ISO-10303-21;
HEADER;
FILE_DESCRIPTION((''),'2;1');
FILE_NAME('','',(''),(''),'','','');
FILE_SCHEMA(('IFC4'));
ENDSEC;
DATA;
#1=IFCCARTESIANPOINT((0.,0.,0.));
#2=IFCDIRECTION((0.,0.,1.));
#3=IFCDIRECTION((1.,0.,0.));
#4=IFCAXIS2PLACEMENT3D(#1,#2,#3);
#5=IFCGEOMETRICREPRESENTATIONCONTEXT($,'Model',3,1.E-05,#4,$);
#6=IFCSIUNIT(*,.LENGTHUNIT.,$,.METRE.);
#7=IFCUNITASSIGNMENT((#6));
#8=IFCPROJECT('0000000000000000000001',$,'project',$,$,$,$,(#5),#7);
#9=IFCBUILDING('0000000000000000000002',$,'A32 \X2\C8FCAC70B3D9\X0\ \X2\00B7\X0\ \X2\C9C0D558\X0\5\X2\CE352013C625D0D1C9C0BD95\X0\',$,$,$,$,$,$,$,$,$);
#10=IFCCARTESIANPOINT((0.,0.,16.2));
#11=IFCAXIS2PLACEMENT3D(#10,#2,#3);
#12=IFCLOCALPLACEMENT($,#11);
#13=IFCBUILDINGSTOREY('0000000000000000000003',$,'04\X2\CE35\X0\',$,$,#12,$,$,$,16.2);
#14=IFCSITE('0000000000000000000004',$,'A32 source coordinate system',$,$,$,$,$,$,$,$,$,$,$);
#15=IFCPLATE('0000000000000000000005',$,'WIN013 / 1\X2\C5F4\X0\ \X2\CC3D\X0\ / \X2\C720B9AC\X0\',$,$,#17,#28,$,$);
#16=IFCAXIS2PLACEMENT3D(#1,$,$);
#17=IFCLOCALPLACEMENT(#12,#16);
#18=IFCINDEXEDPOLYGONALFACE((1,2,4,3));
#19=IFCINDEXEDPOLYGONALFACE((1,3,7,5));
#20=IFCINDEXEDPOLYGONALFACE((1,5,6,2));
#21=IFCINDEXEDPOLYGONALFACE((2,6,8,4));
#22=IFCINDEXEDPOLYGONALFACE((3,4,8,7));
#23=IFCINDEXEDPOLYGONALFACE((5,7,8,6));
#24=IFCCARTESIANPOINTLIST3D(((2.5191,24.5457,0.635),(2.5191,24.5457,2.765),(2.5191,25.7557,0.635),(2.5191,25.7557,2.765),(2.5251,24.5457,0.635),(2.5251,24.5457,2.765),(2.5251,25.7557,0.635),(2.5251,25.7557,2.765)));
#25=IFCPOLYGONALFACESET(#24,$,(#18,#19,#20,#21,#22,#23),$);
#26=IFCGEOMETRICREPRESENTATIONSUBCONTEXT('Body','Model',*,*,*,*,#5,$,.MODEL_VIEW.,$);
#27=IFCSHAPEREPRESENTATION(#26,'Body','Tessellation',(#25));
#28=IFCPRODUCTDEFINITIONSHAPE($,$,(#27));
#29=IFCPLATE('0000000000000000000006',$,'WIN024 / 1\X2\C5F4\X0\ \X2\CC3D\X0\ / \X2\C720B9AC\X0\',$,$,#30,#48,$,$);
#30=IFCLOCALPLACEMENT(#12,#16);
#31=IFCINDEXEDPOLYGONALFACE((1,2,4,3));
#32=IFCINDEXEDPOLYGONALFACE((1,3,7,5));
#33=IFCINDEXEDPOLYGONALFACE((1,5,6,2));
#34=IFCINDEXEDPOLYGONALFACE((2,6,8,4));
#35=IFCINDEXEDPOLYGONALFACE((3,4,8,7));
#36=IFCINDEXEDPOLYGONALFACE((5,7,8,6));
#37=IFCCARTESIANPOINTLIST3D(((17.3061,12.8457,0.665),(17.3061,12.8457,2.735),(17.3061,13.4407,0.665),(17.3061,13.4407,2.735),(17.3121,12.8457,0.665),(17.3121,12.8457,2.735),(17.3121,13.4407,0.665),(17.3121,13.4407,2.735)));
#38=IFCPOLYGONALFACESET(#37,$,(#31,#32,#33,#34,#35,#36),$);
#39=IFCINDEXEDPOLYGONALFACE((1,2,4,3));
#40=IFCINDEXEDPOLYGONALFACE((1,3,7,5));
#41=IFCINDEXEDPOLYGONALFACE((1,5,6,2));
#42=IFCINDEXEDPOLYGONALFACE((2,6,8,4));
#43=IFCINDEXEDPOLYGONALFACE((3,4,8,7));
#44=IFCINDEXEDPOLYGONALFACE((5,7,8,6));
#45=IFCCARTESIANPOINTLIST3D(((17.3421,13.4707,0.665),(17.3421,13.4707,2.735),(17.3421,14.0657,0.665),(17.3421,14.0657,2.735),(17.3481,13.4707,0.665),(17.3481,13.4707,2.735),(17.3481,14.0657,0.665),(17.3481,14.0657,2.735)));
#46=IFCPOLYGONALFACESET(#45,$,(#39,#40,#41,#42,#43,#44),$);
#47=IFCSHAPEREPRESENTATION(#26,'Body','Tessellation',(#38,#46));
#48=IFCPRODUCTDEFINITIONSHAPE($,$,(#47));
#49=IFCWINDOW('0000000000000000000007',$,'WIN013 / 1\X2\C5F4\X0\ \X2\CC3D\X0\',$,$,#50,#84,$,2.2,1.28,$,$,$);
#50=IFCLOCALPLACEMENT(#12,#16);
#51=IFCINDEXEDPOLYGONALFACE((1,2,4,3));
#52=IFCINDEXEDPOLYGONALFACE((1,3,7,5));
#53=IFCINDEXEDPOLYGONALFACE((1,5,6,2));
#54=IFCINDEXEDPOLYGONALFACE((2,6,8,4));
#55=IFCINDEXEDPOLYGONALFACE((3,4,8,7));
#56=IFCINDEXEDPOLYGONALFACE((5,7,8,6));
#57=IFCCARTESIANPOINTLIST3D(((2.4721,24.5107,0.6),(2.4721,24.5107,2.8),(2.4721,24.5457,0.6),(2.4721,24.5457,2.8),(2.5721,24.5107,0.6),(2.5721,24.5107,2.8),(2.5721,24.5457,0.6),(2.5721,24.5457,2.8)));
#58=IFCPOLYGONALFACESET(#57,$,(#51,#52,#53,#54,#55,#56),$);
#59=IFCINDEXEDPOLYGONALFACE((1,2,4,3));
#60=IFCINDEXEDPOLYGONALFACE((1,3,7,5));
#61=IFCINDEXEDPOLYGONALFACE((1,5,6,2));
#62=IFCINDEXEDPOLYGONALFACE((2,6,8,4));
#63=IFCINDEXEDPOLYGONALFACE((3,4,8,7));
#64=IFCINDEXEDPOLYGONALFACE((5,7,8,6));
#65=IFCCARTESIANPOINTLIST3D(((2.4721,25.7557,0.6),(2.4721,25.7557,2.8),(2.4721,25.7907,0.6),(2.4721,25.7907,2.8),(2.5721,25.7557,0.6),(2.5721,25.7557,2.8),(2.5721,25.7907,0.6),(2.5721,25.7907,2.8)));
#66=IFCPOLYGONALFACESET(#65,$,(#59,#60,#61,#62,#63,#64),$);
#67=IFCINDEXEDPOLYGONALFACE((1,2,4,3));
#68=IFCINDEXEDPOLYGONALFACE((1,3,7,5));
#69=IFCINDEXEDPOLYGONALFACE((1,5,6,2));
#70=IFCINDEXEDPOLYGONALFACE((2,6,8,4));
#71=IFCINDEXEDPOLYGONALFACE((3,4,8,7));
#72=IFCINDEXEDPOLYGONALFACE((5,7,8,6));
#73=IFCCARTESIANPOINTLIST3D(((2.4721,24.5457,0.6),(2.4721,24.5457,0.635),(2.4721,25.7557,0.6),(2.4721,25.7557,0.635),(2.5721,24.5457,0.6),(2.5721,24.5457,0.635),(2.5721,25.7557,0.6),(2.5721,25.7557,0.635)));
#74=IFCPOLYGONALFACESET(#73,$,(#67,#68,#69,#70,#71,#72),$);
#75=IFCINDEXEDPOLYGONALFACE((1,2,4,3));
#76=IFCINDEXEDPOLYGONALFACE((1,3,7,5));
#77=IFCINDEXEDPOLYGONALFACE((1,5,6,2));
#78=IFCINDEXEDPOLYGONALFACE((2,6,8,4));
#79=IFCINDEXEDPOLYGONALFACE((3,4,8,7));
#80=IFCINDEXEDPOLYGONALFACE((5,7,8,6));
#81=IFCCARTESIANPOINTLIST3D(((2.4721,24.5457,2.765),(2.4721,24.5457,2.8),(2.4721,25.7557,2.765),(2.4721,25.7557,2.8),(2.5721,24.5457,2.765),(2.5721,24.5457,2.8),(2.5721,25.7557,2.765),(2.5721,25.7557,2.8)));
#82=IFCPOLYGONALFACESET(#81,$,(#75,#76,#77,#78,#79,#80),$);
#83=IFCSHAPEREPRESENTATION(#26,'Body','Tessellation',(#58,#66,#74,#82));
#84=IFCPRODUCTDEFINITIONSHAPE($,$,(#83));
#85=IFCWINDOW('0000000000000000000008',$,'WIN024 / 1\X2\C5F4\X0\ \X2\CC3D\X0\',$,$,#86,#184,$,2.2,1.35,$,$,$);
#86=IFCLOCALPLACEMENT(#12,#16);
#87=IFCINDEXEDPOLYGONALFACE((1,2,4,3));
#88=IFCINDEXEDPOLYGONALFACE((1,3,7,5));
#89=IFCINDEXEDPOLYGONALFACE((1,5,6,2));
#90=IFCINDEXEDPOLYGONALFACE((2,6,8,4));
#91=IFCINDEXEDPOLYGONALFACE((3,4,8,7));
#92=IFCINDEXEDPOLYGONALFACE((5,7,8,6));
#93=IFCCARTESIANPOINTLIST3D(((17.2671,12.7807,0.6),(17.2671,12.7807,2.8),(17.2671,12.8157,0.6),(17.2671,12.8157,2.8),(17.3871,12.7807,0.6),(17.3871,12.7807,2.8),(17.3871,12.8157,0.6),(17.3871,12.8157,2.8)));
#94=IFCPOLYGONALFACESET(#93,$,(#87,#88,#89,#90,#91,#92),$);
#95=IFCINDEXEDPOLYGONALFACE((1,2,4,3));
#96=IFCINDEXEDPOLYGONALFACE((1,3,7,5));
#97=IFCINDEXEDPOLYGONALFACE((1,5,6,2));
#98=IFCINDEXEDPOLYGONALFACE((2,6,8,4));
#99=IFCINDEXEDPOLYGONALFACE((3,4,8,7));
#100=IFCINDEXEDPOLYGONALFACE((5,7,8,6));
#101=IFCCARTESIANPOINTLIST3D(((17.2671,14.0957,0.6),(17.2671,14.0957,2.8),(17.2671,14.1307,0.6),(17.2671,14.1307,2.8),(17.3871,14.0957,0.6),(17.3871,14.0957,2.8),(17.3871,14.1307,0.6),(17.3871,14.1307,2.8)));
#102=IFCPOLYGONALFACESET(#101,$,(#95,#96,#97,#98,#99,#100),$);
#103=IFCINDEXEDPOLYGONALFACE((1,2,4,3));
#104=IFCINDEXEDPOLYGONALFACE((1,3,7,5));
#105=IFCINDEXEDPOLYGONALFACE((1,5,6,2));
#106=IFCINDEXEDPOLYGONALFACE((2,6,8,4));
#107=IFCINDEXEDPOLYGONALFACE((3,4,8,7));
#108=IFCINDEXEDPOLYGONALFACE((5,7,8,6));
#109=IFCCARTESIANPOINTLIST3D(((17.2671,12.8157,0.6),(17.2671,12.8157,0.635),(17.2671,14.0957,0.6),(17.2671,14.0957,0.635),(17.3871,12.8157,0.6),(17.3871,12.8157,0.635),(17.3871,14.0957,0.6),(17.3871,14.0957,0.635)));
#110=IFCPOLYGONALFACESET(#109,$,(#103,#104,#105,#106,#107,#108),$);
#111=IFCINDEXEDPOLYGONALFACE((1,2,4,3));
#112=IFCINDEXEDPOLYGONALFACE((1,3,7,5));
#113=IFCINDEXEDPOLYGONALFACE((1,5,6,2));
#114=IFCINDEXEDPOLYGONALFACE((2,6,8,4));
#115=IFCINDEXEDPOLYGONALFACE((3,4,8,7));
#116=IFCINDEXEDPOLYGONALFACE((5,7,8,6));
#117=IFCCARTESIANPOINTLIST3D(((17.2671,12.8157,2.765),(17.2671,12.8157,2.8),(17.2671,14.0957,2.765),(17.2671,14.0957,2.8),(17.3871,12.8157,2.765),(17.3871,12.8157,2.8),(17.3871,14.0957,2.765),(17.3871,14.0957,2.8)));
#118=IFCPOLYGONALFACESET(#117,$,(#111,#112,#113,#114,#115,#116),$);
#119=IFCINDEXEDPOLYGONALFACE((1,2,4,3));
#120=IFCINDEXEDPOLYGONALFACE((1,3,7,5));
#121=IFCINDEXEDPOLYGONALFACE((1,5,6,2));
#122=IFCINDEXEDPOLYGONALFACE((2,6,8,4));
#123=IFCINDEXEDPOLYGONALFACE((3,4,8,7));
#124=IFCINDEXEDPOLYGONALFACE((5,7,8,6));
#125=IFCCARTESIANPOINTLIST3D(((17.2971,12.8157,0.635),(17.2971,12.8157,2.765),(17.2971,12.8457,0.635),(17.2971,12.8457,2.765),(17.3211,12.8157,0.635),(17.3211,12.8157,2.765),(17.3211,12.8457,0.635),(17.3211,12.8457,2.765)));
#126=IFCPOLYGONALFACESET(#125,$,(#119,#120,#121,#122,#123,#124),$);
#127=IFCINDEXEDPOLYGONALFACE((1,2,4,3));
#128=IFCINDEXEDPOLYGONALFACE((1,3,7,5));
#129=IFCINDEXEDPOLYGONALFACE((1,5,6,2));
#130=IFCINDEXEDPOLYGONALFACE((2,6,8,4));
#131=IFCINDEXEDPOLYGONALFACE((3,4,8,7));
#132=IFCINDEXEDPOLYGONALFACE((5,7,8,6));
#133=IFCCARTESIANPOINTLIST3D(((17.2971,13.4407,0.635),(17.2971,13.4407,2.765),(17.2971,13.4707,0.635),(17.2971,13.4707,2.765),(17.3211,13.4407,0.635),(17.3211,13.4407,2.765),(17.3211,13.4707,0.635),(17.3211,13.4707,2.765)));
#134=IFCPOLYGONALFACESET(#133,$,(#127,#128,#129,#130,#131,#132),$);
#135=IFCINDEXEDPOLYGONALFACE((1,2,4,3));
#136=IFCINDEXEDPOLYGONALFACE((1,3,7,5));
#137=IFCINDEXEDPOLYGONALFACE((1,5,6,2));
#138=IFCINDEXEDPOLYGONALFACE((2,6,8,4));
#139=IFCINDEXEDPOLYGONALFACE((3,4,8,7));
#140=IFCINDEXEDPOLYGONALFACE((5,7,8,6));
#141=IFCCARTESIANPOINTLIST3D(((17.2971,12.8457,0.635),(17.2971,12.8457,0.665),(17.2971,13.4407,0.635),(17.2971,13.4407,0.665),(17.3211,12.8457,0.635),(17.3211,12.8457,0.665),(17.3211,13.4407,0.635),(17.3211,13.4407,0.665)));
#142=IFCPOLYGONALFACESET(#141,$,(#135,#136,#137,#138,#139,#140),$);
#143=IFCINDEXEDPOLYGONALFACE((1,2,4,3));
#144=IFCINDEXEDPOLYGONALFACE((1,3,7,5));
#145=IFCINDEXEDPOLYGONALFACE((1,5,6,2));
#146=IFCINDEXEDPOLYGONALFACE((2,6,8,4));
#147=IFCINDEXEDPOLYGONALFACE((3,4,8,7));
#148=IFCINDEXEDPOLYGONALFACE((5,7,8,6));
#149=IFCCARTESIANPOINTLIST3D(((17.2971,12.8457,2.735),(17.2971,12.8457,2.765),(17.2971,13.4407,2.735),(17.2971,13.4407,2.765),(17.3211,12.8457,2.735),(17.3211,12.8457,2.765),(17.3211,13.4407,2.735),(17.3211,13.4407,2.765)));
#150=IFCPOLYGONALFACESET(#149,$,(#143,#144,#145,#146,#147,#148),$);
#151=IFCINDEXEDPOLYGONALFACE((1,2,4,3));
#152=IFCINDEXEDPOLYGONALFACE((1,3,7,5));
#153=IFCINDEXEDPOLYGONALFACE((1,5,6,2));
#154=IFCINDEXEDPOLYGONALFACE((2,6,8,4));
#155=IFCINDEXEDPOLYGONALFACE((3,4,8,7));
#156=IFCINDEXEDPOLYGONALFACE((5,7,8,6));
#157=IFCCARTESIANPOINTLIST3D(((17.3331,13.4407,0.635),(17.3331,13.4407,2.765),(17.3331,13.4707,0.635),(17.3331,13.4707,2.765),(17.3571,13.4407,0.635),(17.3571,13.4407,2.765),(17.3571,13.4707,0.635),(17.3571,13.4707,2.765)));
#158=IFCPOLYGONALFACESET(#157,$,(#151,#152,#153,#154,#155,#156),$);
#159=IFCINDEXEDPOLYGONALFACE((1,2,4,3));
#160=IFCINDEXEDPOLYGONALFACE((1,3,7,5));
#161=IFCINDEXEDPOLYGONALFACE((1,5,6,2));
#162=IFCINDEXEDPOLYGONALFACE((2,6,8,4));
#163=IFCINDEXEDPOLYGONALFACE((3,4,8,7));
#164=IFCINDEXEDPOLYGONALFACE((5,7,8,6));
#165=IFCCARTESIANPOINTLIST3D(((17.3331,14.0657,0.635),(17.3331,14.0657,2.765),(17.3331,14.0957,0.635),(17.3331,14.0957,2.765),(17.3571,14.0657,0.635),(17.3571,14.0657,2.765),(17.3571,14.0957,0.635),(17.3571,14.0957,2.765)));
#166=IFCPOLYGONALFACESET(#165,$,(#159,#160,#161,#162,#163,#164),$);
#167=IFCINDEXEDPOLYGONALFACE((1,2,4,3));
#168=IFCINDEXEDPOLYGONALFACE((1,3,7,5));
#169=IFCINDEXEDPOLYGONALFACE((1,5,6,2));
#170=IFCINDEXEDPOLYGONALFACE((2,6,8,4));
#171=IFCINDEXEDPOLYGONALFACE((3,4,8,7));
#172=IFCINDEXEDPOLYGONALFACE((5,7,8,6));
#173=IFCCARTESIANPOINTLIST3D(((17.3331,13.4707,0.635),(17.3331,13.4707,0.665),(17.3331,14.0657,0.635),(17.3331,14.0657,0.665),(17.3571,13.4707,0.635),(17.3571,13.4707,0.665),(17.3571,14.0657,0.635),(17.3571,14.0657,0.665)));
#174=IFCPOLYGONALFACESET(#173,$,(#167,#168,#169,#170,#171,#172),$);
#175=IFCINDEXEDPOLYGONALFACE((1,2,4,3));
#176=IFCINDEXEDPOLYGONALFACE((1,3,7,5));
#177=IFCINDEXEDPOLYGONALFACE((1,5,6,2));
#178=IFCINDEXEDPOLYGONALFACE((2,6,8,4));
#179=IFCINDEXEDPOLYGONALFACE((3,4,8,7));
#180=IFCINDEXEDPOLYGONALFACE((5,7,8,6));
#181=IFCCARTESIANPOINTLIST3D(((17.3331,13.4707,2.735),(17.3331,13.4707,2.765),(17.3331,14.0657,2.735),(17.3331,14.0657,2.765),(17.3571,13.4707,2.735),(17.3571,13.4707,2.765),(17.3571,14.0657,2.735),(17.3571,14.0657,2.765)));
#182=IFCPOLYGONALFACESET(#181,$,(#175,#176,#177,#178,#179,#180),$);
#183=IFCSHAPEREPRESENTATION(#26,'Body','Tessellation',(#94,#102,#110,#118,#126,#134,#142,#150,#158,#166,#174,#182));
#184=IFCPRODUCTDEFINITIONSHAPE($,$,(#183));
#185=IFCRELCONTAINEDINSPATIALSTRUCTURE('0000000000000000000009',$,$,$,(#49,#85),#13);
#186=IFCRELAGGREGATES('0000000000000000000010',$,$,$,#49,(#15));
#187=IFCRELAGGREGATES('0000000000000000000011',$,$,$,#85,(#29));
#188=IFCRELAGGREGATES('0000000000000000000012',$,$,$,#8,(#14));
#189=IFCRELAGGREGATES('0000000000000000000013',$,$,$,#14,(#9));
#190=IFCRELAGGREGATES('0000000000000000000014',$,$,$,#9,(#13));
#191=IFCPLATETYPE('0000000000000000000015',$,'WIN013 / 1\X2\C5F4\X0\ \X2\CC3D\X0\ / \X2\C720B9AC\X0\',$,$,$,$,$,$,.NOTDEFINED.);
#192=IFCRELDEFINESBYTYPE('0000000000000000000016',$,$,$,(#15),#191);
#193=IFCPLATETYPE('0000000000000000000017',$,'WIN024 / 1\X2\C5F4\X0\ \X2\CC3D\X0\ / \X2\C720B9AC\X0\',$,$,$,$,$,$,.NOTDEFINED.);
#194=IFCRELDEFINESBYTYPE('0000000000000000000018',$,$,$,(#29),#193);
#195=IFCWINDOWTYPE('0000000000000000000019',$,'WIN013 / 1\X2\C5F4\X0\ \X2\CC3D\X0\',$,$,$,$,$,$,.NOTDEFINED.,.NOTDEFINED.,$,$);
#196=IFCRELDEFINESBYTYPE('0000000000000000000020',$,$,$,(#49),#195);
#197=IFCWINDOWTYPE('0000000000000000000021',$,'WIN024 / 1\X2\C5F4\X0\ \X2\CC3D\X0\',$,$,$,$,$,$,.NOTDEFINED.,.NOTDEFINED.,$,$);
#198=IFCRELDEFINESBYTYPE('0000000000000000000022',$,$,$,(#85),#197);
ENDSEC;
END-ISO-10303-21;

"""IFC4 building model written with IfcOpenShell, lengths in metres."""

from ifc_helpers import new_model, si_unit, frame, origin, origin_with_axes, place, context, subcontext, project, spatial, polyline, outline, extrude, source, transform, mapped, type_object, type_shapes, element, aggregate, save


model = new_model("IFC4")

# Units and contexts
model_context = context("Model", 3, precision=1e-05, world=origin_with_axes())
body_context = subcontext(model_context, "Body", "Model", "MODEL_VIEW")
ifc_project = project(units=[si_unit("LENGTHUNIT", "METRE")], contexts=[model_context])

# Plates
plate_type_1 = type_object("IfcPlateType", Name="WIN013 / 1열 창 / 유리", PredefinedType="NOTDEFINED")
shared_shape_1 = source(origin(), body_context, "Body", "SweptSolid", [
    extrude(outline(polyline([(2.5191, 24.5457), (2.5191, 25.7557), (2.5251, 25.7557), (2.5251, 24.5457), (2.5191, 24.5457)])), frame((0.0, 0.0, 0.635)), (0.0, 0.0, 1.0), 2.13),
])
type_shapes(plate_type_1, [shared_shape_1])
storey_placement = place(None, frame((0.0, 0.0, 16.2), z_axis=(0.0, 0.0, 1.0), x_axis=(1.0, 0.0, 0.0)))
window_1_placement = place(storey_placement, origin_with_axes())
plate_1_placement = place(window_1_placement, origin_with_axes())
plate_1 = element("IfcPlate", 1, at=plate_1_placement, type_object=plate_type_1, Name="WIN013 / 1열 창 / 유리", context=body_context, shape_type="MappedRepresentation", body=[
    mapped(shared_shape_1, transform((0.0, 0.0, 0.0), scale=1.0)),
])
plate_type_2 = type_object("IfcPlateType", Name="WIN024 / 1열 창 / 유리", PredefinedType="NOTDEFINED")
shared_shape_2 = source(origin(), body_context, "Body", "SweptSolid", [
    extrude(outline(polyline([(17.3061, 12.8457), (17.3061, 13.4407), (17.3121, 13.4407), (17.3121, 12.8457), (17.3061, 12.8457)])), frame((0.0, 0.0, 0.665)), (0.0, 0.0, 1.0), 2.07),
    extrude(outline(polyline([(17.3421, 13.4707), (17.3421, 14.0657), (17.3481, 14.0657), (17.3481, 13.4707), (17.3421, 13.4707)])), frame((0.0, 0.0, 0.665)), (0.0, 0.0, 1.0), 2.07),
])
type_shapes(plate_type_2, [shared_shape_2])
window_2_placement = place(storey_placement, origin_with_axes())
plate_2_placement = place(window_2_placement, origin_with_axes())
plate_2 = element("IfcPlate", 2, at=plate_2_placement, type_object=plate_type_2, Name="WIN024 / 1열 창 / 유리", context=body_context, shape_type="MappedRepresentation", body=[
    mapped(shared_shape_2, transform((0.0, 0.0, 0.0), scale=1.0)),
])

# Site, building, storey
site = spatial("IfcSite", under=ifc_project, Name="A32 source coordinate system")
building = spatial("IfcBuilding", under=site, Name="A32 주거동 · 지하5층–옥탑지붕")
storey = spatial("IfcBuildingStorey", under=building, at=storey_placement, Name="04층", Elevation=16.2)

# Windows
window_type_1 = type_object("IfcWindowType", Name="WIN013 / 1열 창", PartitioningType="NOTDEFINED", PredefinedType="NOTDEFINED")
shared_shape_3 = source(origin(), body_context, "Body", "SweptSolid", [
    extrude(outline(polyline([(2.4721, 24.5107), (2.4721, 24.5457), (2.5721, 24.5457), (2.5721, 24.5107), (2.4721, 24.5107)])), frame((0.0, 0.0, 0.6)), (0.0, 0.0, 1.0), 2.2),
    extrude(outline(polyline([(2.4721, 25.7557), (2.4721, 25.7907), (2.5721, 25.7907), (2.5721, 25.7557), (2.4721, 25.7557)])), frame((0.0, 0.0, 0.6)), (0.0, 0.0, 1.0), 2.2),
    extrude(outline(polyline([(2.4721, 24.5457), (2.4721, 25.7557), (2.5721, 25.7557), (2.5721, 24.5457), (2.4721, 24.5457)])), frame((0.0, 0.0, 0.6)), (0.0, 0.0, 1.0), 0.035),
    extrude(outline(polyline([(2.4721, 24.5457), (2.4721, 25.7557), (2.5721, 25.7557), (2.5721, 24.5457), (2.4721, 24.5457)])), frame((0.0, 0.0, 2.765)), (0.0, 0.0, 1.0), 0.035),
])
type_shapes(window_type_1, [shared_shape_3])
window_1 = element("IfcWindow", 3, at=window_1_placement, inside=storey, type_object=window_type_1, Name="WIN013 / 1열 창", OverallHeight=2.2, OverallWidth=1.28, context=body_context, shape_type="MappedRepresentation", body=[
    mapped(shared_shape_3, transform((0.0, 0.0, 0.0), scale=1.0)),
])
aggregate(window_1, [plate_1])
window_type_2 = type_object("IfcWindowType", Name="WIN024 / 1열 창", PartitioningType="NOTDEFINED", PredefinedType="NOTDEFINED")
shared_shape_4 = source(origin(), body_context, "Body", "SweptSolid", [
    extrude(outline(polyline([(17.2671, 12.7807), (17.2671, 12.8157), (17.3871, 12.8157), (17.3871, 12.7807), (17.2671, 12.7807)])), frame((0.0, 0.0, 0.6)), (0.0, 0.0, 1.0), 2.2),
    extrude(outline(polyline([(17.2671, 14.0957), (17.2671, 14.1307), (17.3871, 14.1307), (17.3871, 14.0957), (17.2671, 14.0957)])), frame((0.0, 0.0, 0.6)), (0.0, 0.0, 1.0), 2.2),
    extrude(outline(polyline([(17.2671, 12.8157), (17.2671, 14.0957), (17.3871, 14.0957), (17.3871, 12.8157), (17.2671, 12.8157)])), frame((0.0, 0.0, 0.6)), (0.0, 0.0, 1.0), 0.035),
    extrude(outline(polyline([(17.2671, 12.8157), (17.2671, 14.0957), (17.3871, 14.0957), (17.3871, 12.8157), (17.2671, 12.8157)])), frame((0.0, 0.0, 2.765)), (0.0, 0.0, 1.0), 0.035),
    extrude(outline(polyline([(17.2971, 12.8157), (17.2971, 12.8457), (17.3211, 12.8457), (17.3211, 12.8157), (17.2971, 12.8157)])), frame((0.0, 0.0, 0.635)), (0.0, 0.0, 1.0), 2.13),
    extrude(outline(polyline([(17.2971, 13.4407), (17.2971, 13.4707), (17.3211, 13.4707), (17.3211, 13.4407), (17.2971, 13.4407)])), frame((0.0, 0.0, 0.635)), (0.0, 0.0, 1.0), 2.13),
    extrude(outline(polyline([(17.2971, 12.8457), (17.2971, 13.4407), (17.3211, 13.4407), (17.3211, 12.8457), (17.2971, 12.8457)])), frame((0.0, 0.0, 0.635)), (0.0, 0.0, 1.0), 0.03),
    extrude(outline(polyline([(17.2971, 12.8457), (17.2971, 13.4407), (17.3211, 13.4407), (17.3211, 12.8457), (17.2971, 12.8457)])), frame((0.0, 0.0, 2.735)), (0.0, 0.0, 1.0), 0.03),
    extrude(outline(polyline([(17.3331, 13.4407), (17.3331, 13.4707), (17.3571, 13.4707), (17.3571, 13.4407), (17.3331, 13.4407)])), frame((0.0, 0.0, 0.635)), (0.0, 0.0, 1.0), 2.13),
    extrude(outline(polyline([(17.3331, 14.0657), (17.3331, 14.0957), (17.3571, 14.0957), (17.3571, 14.0657), (17.3331, 14.0657)])), frame((0.0, 0.0, 0.635)), (0.0, 0.0, 1.0), 2.13),
    extrude(outline(polyline([(17.3331, 13.4707), (17.3331, 14.0657), (17.3571, 14.0657), (17.3571, 13.4707), (17.3331, 13.4707)])), frame((0.0, 0.0, 0.635)), (0.0, 0.0, 1.0), 0.03),
    extrude(outline(polyline([(17.3331, 13.4707), (17.3331, 14.0657), (17.3571, 14.0657), (17.3571, 13.4707), (17.3331, 13.4707)])), frame((0.0, 0.0, 2.735)), (0.0, 0.0, 1.0), 0.03),
])
type_shapes(window_type_2, [shared_shape_4])
window_2 = element("IfcWindow", 4, at=window_2_placement, inside=storey, type_object=window_type_2, Name="WIN024 / 1열 창", OverallHeight=2.2, OverallWidth=1.35, context=body_context, shape_type="MappedRepresentation", body=[
    mapped(shared_shape_4, transform((0.0, 0.0, 0.0), scale=1.0)),
])
aggregate(window_2, [plate_2])

save(model, "model.ifc")
